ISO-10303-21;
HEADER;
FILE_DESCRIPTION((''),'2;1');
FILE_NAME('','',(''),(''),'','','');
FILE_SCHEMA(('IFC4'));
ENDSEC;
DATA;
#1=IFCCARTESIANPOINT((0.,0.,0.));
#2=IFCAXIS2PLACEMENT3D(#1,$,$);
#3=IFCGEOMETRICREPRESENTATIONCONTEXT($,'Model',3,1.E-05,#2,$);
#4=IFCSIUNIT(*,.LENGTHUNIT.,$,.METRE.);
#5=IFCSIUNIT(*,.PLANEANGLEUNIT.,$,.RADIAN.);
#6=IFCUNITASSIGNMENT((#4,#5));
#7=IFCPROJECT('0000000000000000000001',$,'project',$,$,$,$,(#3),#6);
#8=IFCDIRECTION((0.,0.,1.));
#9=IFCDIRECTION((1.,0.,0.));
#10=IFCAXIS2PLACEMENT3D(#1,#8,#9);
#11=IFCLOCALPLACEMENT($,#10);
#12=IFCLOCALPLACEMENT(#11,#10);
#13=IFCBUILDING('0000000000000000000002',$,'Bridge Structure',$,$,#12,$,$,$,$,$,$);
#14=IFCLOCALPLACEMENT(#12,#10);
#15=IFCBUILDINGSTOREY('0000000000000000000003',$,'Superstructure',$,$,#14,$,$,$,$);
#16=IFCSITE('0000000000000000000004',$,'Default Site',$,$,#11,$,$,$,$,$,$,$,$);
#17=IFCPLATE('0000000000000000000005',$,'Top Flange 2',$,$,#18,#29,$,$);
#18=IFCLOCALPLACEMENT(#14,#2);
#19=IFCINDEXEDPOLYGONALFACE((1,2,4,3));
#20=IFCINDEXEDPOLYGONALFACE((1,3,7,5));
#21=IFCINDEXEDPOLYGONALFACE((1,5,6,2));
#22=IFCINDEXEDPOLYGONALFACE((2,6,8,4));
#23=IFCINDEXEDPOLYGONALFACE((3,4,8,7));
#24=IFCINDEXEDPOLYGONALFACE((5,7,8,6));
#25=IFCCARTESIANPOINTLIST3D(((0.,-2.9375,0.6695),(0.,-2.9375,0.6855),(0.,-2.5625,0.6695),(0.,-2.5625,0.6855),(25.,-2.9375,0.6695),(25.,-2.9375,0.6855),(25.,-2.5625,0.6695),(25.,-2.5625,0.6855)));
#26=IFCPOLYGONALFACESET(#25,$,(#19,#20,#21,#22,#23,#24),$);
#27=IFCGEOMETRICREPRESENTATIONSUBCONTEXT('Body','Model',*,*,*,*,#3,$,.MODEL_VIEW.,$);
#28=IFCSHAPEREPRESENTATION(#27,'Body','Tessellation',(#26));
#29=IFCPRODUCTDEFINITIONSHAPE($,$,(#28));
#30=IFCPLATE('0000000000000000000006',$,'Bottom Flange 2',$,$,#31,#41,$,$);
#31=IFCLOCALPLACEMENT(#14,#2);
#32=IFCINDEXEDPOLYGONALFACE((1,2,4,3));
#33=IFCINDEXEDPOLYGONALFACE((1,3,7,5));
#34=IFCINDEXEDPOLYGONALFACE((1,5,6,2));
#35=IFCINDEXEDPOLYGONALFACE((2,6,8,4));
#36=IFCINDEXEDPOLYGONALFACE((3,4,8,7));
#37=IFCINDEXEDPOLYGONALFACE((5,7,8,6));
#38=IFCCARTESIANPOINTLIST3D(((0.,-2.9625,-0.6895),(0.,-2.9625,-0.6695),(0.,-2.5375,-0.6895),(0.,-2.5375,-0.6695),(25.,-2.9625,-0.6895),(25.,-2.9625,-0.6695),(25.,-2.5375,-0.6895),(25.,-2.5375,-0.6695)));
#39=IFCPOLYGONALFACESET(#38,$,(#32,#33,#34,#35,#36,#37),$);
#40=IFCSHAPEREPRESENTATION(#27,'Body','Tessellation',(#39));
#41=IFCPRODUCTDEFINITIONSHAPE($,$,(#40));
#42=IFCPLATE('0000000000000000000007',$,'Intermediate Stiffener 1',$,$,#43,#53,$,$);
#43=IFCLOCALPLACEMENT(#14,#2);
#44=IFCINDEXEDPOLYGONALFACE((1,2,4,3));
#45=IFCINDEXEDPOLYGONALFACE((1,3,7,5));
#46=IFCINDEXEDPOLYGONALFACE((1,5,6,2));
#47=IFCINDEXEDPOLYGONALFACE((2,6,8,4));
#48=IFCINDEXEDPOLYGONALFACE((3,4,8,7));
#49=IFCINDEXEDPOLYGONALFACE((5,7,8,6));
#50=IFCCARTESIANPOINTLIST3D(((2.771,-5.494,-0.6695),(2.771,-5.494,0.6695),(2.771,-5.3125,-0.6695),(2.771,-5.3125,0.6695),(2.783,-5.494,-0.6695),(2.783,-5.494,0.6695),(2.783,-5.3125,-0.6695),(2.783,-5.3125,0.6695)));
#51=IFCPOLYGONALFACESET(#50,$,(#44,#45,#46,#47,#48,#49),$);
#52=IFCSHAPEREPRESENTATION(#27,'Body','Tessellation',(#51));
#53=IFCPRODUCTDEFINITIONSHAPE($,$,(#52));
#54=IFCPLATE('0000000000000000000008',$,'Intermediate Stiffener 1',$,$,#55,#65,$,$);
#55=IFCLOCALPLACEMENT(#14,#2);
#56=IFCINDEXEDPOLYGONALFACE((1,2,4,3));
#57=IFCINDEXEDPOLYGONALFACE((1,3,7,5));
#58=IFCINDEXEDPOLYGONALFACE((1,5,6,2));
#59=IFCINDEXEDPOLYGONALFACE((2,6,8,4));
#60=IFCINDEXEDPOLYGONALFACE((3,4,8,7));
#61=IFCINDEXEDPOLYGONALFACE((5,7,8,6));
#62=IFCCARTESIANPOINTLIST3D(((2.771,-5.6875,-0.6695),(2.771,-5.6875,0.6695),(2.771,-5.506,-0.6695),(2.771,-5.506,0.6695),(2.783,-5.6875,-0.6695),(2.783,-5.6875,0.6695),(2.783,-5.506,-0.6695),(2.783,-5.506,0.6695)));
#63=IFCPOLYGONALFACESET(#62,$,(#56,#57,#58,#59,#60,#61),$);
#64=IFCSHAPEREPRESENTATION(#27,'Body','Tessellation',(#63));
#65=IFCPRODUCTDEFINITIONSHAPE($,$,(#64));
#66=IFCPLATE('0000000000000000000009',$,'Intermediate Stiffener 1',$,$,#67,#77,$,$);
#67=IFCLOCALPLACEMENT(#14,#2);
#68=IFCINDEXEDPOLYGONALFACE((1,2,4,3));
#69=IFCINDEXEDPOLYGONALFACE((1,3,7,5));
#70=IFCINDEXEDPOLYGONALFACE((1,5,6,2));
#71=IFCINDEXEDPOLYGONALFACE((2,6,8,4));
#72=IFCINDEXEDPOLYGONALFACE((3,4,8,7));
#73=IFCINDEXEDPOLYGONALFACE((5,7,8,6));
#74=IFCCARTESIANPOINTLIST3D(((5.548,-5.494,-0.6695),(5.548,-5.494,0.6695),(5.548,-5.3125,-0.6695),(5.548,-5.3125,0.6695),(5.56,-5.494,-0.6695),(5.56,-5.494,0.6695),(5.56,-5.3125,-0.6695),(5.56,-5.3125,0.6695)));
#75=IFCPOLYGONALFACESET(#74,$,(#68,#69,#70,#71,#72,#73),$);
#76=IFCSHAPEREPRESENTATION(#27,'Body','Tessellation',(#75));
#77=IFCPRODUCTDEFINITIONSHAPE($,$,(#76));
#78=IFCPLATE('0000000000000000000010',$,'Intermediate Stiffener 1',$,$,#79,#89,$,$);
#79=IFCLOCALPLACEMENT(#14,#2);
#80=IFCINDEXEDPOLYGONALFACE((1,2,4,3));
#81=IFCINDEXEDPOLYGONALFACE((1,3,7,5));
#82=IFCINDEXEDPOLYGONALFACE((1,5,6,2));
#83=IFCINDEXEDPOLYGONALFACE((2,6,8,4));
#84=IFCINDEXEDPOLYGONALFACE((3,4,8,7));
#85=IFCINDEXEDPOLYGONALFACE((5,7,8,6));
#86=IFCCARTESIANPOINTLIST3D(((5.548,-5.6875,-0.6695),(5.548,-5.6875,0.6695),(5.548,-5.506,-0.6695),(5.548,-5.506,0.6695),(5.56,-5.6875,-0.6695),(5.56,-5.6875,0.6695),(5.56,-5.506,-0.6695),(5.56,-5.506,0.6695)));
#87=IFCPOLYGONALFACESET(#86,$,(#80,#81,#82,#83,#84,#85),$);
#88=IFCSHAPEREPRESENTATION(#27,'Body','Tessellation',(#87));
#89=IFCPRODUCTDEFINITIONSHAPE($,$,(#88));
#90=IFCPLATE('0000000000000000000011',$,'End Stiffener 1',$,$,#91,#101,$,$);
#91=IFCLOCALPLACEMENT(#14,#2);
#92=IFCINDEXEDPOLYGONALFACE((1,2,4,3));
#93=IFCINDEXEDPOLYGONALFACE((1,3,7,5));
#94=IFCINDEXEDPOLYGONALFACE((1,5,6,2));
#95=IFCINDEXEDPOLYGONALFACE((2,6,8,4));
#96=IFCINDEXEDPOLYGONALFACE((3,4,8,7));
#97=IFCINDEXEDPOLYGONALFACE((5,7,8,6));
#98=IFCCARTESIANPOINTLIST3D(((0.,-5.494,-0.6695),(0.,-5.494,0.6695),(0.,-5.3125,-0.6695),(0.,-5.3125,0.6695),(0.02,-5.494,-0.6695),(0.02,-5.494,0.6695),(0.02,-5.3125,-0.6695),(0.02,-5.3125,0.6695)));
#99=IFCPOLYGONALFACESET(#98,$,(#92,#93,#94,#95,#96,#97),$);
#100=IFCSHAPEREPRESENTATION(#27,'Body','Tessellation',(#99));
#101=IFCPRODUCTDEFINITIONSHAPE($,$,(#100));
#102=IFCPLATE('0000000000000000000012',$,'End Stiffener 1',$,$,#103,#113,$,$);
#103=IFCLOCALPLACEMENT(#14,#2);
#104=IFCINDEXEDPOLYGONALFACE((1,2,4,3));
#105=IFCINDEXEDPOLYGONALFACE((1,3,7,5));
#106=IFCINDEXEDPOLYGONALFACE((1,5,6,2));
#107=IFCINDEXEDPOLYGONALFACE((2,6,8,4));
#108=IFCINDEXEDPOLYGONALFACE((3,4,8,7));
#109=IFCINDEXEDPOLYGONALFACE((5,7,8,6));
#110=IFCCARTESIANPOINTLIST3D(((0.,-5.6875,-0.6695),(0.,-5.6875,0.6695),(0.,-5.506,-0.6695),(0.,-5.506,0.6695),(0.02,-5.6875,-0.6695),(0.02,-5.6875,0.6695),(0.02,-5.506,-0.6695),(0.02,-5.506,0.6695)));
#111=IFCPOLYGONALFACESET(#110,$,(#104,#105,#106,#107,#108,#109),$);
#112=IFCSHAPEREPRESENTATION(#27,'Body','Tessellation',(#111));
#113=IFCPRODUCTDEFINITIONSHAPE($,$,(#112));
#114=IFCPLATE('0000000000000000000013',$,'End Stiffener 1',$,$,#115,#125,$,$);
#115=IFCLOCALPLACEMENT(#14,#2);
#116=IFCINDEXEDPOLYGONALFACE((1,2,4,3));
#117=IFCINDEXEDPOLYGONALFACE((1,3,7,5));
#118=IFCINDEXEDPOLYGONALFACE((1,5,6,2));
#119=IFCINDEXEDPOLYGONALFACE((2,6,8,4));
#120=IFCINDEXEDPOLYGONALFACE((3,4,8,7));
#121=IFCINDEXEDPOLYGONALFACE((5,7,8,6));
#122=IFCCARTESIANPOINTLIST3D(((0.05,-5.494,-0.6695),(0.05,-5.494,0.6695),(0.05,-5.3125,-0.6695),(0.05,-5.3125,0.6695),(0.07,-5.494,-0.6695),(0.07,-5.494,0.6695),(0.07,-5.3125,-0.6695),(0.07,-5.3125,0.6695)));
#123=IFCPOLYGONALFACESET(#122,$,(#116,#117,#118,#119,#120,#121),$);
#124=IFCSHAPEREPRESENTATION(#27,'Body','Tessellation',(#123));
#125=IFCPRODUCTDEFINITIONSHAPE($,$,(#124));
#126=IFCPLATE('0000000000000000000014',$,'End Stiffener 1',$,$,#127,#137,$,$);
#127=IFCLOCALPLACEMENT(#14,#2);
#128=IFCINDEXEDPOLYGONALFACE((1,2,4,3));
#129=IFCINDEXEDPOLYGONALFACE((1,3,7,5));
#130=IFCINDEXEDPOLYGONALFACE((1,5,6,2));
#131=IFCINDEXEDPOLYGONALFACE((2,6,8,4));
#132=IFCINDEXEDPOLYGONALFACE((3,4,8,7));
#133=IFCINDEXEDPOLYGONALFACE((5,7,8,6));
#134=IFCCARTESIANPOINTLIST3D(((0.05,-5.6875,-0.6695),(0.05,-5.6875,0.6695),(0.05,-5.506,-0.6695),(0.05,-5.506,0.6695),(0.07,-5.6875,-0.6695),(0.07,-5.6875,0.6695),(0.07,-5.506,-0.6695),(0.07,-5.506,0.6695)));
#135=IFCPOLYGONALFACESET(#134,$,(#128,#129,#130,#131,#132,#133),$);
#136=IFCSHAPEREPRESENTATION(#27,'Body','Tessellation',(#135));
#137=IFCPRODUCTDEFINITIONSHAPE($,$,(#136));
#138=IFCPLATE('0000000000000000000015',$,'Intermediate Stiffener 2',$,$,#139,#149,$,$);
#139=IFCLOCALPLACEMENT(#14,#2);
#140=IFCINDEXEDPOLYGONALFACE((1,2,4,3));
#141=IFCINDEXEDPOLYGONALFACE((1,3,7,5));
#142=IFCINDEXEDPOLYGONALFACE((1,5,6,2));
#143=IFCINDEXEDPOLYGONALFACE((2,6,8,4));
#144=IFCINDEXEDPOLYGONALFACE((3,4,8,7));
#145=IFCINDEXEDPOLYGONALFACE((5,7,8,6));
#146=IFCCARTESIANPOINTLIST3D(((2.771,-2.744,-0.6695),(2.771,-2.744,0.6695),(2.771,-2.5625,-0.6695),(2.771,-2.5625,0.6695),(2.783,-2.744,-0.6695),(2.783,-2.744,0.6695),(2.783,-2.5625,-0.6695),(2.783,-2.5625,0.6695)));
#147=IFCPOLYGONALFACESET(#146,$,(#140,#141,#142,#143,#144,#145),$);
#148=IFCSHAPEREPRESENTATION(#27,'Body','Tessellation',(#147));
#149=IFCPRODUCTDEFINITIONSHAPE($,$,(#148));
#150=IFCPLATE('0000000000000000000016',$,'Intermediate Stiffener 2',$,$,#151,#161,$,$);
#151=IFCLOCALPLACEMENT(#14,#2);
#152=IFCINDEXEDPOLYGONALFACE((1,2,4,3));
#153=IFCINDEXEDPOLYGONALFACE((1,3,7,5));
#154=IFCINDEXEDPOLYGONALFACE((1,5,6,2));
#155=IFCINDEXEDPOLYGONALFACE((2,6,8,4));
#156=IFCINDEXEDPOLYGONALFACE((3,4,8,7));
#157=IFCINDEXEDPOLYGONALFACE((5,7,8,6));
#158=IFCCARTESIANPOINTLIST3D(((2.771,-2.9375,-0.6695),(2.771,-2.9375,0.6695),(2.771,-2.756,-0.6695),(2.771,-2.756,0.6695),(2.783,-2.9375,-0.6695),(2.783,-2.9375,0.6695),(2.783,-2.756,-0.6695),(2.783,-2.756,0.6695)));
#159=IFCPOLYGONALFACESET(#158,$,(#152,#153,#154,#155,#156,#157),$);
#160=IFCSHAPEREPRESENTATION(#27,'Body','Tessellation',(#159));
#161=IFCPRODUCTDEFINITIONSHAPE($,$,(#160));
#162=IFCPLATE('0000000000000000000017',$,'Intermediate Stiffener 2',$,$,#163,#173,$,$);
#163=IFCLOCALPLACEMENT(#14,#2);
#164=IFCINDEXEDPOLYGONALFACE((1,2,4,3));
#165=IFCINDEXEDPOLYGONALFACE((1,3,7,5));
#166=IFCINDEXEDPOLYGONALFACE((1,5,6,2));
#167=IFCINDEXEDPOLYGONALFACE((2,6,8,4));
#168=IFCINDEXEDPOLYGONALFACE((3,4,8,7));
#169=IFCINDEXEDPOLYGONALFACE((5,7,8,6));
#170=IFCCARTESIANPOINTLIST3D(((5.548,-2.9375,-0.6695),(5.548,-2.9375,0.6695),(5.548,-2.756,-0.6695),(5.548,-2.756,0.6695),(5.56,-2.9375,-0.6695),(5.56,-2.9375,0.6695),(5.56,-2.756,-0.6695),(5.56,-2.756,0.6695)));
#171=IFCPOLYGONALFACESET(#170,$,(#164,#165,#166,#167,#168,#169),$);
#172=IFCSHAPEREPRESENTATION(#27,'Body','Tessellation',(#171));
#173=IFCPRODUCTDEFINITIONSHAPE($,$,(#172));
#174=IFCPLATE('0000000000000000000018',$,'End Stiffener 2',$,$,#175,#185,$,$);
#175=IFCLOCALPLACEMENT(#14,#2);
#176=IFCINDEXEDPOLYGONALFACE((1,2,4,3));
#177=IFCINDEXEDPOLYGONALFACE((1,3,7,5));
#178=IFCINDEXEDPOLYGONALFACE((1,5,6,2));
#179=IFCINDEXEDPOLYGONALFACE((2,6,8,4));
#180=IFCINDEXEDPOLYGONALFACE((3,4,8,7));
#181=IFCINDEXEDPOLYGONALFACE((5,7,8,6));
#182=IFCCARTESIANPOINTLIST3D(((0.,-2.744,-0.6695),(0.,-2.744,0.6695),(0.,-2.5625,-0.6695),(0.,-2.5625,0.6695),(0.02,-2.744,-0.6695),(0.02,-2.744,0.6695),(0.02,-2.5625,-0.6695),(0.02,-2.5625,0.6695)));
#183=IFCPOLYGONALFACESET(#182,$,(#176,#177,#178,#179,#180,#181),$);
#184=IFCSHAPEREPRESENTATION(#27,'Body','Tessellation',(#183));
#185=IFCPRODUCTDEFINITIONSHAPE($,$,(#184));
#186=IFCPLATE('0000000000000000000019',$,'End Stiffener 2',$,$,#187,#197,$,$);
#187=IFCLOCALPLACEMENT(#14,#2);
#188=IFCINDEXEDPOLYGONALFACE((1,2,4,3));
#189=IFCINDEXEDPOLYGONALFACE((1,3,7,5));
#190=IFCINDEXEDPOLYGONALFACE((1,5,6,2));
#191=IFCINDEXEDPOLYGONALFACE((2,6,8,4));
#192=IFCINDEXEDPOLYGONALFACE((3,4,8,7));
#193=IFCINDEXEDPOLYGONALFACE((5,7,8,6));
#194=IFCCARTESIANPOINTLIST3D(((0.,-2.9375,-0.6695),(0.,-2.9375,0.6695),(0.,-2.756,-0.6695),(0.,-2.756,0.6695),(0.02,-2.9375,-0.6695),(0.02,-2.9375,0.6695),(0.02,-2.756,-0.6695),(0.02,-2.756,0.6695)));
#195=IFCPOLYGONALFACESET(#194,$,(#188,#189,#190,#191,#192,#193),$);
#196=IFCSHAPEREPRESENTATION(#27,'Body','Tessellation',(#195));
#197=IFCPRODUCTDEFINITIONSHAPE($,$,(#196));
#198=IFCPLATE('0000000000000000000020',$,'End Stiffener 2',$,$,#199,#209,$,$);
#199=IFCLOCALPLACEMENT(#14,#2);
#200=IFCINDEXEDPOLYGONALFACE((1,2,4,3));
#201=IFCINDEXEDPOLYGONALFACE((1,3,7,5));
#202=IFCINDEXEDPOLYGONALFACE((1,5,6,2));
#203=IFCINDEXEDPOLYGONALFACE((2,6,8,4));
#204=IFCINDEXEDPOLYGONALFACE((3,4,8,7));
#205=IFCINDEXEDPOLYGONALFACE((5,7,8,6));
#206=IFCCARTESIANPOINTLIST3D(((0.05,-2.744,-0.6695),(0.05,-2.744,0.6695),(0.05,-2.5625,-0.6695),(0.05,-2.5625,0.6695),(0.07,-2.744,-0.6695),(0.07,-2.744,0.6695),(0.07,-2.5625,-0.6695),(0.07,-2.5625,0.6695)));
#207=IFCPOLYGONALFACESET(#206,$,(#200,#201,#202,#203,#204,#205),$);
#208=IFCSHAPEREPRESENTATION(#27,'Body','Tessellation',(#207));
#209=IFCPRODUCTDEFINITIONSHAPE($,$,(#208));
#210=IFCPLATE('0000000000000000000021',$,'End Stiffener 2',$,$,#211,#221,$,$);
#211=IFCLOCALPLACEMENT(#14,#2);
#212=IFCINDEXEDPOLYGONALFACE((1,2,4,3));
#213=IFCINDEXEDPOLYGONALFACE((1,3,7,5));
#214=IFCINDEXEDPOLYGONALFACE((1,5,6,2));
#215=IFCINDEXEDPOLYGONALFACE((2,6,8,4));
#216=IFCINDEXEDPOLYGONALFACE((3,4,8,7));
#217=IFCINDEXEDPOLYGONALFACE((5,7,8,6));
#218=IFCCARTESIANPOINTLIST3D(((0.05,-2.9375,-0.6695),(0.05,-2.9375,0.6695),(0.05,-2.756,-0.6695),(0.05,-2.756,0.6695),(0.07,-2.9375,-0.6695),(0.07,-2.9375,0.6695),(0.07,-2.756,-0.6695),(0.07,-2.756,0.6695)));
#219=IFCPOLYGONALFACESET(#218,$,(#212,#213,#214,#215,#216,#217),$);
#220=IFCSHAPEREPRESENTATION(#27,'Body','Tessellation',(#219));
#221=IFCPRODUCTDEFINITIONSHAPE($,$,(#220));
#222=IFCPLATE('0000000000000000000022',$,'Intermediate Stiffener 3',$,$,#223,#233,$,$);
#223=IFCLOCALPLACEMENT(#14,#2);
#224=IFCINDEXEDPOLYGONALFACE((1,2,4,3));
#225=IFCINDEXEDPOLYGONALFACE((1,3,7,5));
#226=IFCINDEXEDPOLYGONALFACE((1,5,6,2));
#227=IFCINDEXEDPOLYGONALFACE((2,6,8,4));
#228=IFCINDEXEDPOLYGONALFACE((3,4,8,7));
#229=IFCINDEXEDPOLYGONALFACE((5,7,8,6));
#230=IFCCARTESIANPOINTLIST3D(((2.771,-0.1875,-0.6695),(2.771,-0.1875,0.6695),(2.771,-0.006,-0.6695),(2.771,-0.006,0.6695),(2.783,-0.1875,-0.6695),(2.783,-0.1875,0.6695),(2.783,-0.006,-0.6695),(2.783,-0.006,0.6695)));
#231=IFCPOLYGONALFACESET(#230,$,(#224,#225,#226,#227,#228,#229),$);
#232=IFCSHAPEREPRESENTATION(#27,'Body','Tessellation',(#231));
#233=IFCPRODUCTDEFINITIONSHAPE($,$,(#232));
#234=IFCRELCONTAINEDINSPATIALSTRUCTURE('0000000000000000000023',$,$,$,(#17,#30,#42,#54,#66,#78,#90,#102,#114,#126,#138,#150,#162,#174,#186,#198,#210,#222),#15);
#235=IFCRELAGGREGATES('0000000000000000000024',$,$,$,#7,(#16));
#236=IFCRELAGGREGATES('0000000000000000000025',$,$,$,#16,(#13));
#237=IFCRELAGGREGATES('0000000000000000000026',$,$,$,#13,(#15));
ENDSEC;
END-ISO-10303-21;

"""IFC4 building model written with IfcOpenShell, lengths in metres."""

from ifc_helpers import new_model, si_unit, frame, origin, origin_with_axes, origin_2d_with_axis, place, context, subcontext, project, spatial, rectangle, extrude, element, save


model = new_model("IFC4")

# Units and contexts
model_context = context("Model", 3, precision=1e-05, world=origin())
body_context = subcontext(model_context, "Body", "Model", "MODEL_VIEW")
ifc_project = project(units=[si_unit("LENGTHUNIT", "METRE"), si_unit("PLANEANGLEUNIT", "RADIAN")], contexts=[model_context])

# Site, building, storey
site_placement = place(None, origin_with_axes())
site = spatial("IfcSite", under=ifc_project, at=site_placement, Name="Default Site")
building_placement = place(site_placement, origin_with_axes())
building = spatial("IfcBuilding", under=site, at=building_placement, Name="Bridge Structure")
storey_placement = place(building_placement, origin_with_axes())
storey = spatial("IfcBuildingStorey", under=building, at=storey_placement, Name="Superstructure")

# Plates
plate_1_placement = place(storey_placement, frame((0.0, -2.75, 0.6775), z_axis=(1.0, 0.0, 0.0), x_axis=(0.0, 1.0, 0.0)))
element("IfcPlate", 1, at=plate_1_placement, inside=storey, Name="Top Flange 2", context=body_context, shape_type="SweptSolid", body=[
    extrude(rectangle(XDim=0.375, YDim=0.016, at=origin_2d_with_axis()), origin_with_axes(), (0.0, 0.0, 1.0), 25.0),
])
plate_2_placement = place(storey_placement, frame((0.0, -2.75, -0.6795), z_axis=(1.0, 0.0, 0.0), x_axis=(0.0, 1.0, 0.0)))
element("IfcPlate", 2, at=plate_2_placement, inside=storey, Name="Bottom Flange 2", context=body_context, shape_type="SweptSolid", body=[
    extrude(rectangle(XDim=0.425, YDim=0.02, at=origin_2d_with_axis()), origin_with_axes(), (0.0, 0.0, 1.0), 25.0),
])
for number, where, z_axis, x_axis, name in (
    (3, (2.777, -5.4032, -0.6695), (0.0, 0.0, 1.0), (1.0, 0.0, 0.0), "Intermediate Stiffener 1"),
    (4, (2.777, -5.5968, -0.6695), (0.0, 0.0, 1.0), (1.0, 0.0, 0.0), "Intermediate Stiffener 1"),
    (5, (5.554, -5.4032, -0.6695), (0.0, 0.0, 1.0), (1.0, 0.0, 0.0), "Intermediate Stiffener 1"),
    (6, (5.554, -5.5968, -0.6695), (0.0, 0.0, 1.0), (1.0, 0.0, 0.0), "Intermediate Stiffener 1"),
):
    element("IfcPlate", number, at=place(storey_placement, frame(where, z_axis=z_axis, x_axis=x_axis)), inside=storey, Name=name, context=body_context, shape_type="SweptSolid", body=[
        extrude(rectangle(XDim=0.012, YDim=0.1815, at=origin_2d_with_axis()), origin_with_axes(), (0.0, 0.0, 1.0), 1.339),
    ])
for number, where, z_axis, x_axis, name in (
    (7, (0.01, -5.4032, -0.6695), (0.0, 0.0, 1.0), (1.0, 0.0, 0.0), "End Stiffener 1"),
    (8, (0.01, -5.5968, -0.6695), (0.0, 0.0, 1.0), (1.0, 0.0, 0.0), "End Stiffener 1"),
    (9, (0.06, -5.4032, -0.6695), (0.0, 0.0, 1.0), (1.0, 0.0, 0.0), "End Stiffener 1"),
    (10, (0.06, -5.5968, -0.6695), (0.0, 0.0, 1.0), (1.0, 0.0, 0.0), "End Stiffener 1"),
):
    element("IfcPlate", number, at=place(storey_placement, frame(where, z_axis=z_axis, x_axis=x_axis)), inside=storey, Name=name, context=body_context, shape_type="SweptSolid", body=[
        extrude(rectangle(XDim=0.02, YDim=0.1815, at=origin_2d_with_axis()), origin_with_axes(), (0.0, 0.0, 1.0), 1.339),
    ])
for number, where, z_axis, x_axis, name in (
    (11, (2.777, -2.6532, -0.6695), (0.0, 0.0, 1.0), (1.0, 0.0, 0.0), "Intermediate Stiffener 2"),
    (12, (2.777, -2.8468, -0.6695), (0.0, 0.0, 1.0), (1.0, 0.0, 0.0), "Intermediate Stiffener 2"),
    (13, (5.554, -2.8468, -0.6695), (0.0, 0.0, 1.0), (1.0, 0.0, 0.0), "Intermediate Stiffener 2"),
):
    element("IfcPlate", number, at=place(storey_placement, frame(where, z_axis=z_axis, x_axis=x_axis)), inside=storey, Name=name, context=body_context, shape_type="SweptSolid", body=[
        extrude(rectangle(XDim=0.012, YDim=0.1815, at=origin_2d_with_axis()), origin_with_axes(), (0.0, 0.0, 1.0), 1.339),
    ])
for number, where, z_axis, x_axis, name in (
    (14, (0.01, -2.6532, -0.6695), (0.0, 0.0, 1.0), (1.0, 0.0, 0.0), "End Stiffener 2"),
    (15, (0.01, -2.8468, -0.6695), (0.0, 0.0, 1.0), (1.0, 0.0, 0.0), "End Stiffener 2"),
    (16, (0.06, -2.6532, -0.6695), (0.0, 0.0, 1.0), (1.0, 0.0, 0.0), "End Stiffener 2"),
    (17, (0.06, -2.8468, -0.6695), (0.0, 0.0, 1.0), (1.0, 0.0, 0.0), "End Stiffener 2"),
):
    element("IfcPlate", number, at=place(storey_placement, frame(where, z_axis=z_axis, x_axis=x_axis)), inside=storey, Name=name, context=body_context, shape_type="SweptSolid", body=[
        extrude(rectangle(XDim=0.02, YDim=0.1815, at=origin_2d_with_axis()), origin_with_axes(), (0.0, 0.0, 1.0), 1.339),
    ])
plate_3_placement = place(storey_placement, frame((2.777, -0.0968, -0.6695), z_axis=(0.0, 0.0, 1.0), x_axis=(1.0, 0.0, 0.0)))
element("IfcPlate", 18, at=plate_3_placement, inside=storey, Name="Intermediate Stiffener 3", context=body_context, shape_type="SweptSolid", body=[
    extrude(rectangle(XDim=0.012, YDim=0.1815, at=origin_2d_with_axis()), origin_with_axes(), (0.0, 0.0, 1.0), 1.339),
])

save(model, "model.ifc")
